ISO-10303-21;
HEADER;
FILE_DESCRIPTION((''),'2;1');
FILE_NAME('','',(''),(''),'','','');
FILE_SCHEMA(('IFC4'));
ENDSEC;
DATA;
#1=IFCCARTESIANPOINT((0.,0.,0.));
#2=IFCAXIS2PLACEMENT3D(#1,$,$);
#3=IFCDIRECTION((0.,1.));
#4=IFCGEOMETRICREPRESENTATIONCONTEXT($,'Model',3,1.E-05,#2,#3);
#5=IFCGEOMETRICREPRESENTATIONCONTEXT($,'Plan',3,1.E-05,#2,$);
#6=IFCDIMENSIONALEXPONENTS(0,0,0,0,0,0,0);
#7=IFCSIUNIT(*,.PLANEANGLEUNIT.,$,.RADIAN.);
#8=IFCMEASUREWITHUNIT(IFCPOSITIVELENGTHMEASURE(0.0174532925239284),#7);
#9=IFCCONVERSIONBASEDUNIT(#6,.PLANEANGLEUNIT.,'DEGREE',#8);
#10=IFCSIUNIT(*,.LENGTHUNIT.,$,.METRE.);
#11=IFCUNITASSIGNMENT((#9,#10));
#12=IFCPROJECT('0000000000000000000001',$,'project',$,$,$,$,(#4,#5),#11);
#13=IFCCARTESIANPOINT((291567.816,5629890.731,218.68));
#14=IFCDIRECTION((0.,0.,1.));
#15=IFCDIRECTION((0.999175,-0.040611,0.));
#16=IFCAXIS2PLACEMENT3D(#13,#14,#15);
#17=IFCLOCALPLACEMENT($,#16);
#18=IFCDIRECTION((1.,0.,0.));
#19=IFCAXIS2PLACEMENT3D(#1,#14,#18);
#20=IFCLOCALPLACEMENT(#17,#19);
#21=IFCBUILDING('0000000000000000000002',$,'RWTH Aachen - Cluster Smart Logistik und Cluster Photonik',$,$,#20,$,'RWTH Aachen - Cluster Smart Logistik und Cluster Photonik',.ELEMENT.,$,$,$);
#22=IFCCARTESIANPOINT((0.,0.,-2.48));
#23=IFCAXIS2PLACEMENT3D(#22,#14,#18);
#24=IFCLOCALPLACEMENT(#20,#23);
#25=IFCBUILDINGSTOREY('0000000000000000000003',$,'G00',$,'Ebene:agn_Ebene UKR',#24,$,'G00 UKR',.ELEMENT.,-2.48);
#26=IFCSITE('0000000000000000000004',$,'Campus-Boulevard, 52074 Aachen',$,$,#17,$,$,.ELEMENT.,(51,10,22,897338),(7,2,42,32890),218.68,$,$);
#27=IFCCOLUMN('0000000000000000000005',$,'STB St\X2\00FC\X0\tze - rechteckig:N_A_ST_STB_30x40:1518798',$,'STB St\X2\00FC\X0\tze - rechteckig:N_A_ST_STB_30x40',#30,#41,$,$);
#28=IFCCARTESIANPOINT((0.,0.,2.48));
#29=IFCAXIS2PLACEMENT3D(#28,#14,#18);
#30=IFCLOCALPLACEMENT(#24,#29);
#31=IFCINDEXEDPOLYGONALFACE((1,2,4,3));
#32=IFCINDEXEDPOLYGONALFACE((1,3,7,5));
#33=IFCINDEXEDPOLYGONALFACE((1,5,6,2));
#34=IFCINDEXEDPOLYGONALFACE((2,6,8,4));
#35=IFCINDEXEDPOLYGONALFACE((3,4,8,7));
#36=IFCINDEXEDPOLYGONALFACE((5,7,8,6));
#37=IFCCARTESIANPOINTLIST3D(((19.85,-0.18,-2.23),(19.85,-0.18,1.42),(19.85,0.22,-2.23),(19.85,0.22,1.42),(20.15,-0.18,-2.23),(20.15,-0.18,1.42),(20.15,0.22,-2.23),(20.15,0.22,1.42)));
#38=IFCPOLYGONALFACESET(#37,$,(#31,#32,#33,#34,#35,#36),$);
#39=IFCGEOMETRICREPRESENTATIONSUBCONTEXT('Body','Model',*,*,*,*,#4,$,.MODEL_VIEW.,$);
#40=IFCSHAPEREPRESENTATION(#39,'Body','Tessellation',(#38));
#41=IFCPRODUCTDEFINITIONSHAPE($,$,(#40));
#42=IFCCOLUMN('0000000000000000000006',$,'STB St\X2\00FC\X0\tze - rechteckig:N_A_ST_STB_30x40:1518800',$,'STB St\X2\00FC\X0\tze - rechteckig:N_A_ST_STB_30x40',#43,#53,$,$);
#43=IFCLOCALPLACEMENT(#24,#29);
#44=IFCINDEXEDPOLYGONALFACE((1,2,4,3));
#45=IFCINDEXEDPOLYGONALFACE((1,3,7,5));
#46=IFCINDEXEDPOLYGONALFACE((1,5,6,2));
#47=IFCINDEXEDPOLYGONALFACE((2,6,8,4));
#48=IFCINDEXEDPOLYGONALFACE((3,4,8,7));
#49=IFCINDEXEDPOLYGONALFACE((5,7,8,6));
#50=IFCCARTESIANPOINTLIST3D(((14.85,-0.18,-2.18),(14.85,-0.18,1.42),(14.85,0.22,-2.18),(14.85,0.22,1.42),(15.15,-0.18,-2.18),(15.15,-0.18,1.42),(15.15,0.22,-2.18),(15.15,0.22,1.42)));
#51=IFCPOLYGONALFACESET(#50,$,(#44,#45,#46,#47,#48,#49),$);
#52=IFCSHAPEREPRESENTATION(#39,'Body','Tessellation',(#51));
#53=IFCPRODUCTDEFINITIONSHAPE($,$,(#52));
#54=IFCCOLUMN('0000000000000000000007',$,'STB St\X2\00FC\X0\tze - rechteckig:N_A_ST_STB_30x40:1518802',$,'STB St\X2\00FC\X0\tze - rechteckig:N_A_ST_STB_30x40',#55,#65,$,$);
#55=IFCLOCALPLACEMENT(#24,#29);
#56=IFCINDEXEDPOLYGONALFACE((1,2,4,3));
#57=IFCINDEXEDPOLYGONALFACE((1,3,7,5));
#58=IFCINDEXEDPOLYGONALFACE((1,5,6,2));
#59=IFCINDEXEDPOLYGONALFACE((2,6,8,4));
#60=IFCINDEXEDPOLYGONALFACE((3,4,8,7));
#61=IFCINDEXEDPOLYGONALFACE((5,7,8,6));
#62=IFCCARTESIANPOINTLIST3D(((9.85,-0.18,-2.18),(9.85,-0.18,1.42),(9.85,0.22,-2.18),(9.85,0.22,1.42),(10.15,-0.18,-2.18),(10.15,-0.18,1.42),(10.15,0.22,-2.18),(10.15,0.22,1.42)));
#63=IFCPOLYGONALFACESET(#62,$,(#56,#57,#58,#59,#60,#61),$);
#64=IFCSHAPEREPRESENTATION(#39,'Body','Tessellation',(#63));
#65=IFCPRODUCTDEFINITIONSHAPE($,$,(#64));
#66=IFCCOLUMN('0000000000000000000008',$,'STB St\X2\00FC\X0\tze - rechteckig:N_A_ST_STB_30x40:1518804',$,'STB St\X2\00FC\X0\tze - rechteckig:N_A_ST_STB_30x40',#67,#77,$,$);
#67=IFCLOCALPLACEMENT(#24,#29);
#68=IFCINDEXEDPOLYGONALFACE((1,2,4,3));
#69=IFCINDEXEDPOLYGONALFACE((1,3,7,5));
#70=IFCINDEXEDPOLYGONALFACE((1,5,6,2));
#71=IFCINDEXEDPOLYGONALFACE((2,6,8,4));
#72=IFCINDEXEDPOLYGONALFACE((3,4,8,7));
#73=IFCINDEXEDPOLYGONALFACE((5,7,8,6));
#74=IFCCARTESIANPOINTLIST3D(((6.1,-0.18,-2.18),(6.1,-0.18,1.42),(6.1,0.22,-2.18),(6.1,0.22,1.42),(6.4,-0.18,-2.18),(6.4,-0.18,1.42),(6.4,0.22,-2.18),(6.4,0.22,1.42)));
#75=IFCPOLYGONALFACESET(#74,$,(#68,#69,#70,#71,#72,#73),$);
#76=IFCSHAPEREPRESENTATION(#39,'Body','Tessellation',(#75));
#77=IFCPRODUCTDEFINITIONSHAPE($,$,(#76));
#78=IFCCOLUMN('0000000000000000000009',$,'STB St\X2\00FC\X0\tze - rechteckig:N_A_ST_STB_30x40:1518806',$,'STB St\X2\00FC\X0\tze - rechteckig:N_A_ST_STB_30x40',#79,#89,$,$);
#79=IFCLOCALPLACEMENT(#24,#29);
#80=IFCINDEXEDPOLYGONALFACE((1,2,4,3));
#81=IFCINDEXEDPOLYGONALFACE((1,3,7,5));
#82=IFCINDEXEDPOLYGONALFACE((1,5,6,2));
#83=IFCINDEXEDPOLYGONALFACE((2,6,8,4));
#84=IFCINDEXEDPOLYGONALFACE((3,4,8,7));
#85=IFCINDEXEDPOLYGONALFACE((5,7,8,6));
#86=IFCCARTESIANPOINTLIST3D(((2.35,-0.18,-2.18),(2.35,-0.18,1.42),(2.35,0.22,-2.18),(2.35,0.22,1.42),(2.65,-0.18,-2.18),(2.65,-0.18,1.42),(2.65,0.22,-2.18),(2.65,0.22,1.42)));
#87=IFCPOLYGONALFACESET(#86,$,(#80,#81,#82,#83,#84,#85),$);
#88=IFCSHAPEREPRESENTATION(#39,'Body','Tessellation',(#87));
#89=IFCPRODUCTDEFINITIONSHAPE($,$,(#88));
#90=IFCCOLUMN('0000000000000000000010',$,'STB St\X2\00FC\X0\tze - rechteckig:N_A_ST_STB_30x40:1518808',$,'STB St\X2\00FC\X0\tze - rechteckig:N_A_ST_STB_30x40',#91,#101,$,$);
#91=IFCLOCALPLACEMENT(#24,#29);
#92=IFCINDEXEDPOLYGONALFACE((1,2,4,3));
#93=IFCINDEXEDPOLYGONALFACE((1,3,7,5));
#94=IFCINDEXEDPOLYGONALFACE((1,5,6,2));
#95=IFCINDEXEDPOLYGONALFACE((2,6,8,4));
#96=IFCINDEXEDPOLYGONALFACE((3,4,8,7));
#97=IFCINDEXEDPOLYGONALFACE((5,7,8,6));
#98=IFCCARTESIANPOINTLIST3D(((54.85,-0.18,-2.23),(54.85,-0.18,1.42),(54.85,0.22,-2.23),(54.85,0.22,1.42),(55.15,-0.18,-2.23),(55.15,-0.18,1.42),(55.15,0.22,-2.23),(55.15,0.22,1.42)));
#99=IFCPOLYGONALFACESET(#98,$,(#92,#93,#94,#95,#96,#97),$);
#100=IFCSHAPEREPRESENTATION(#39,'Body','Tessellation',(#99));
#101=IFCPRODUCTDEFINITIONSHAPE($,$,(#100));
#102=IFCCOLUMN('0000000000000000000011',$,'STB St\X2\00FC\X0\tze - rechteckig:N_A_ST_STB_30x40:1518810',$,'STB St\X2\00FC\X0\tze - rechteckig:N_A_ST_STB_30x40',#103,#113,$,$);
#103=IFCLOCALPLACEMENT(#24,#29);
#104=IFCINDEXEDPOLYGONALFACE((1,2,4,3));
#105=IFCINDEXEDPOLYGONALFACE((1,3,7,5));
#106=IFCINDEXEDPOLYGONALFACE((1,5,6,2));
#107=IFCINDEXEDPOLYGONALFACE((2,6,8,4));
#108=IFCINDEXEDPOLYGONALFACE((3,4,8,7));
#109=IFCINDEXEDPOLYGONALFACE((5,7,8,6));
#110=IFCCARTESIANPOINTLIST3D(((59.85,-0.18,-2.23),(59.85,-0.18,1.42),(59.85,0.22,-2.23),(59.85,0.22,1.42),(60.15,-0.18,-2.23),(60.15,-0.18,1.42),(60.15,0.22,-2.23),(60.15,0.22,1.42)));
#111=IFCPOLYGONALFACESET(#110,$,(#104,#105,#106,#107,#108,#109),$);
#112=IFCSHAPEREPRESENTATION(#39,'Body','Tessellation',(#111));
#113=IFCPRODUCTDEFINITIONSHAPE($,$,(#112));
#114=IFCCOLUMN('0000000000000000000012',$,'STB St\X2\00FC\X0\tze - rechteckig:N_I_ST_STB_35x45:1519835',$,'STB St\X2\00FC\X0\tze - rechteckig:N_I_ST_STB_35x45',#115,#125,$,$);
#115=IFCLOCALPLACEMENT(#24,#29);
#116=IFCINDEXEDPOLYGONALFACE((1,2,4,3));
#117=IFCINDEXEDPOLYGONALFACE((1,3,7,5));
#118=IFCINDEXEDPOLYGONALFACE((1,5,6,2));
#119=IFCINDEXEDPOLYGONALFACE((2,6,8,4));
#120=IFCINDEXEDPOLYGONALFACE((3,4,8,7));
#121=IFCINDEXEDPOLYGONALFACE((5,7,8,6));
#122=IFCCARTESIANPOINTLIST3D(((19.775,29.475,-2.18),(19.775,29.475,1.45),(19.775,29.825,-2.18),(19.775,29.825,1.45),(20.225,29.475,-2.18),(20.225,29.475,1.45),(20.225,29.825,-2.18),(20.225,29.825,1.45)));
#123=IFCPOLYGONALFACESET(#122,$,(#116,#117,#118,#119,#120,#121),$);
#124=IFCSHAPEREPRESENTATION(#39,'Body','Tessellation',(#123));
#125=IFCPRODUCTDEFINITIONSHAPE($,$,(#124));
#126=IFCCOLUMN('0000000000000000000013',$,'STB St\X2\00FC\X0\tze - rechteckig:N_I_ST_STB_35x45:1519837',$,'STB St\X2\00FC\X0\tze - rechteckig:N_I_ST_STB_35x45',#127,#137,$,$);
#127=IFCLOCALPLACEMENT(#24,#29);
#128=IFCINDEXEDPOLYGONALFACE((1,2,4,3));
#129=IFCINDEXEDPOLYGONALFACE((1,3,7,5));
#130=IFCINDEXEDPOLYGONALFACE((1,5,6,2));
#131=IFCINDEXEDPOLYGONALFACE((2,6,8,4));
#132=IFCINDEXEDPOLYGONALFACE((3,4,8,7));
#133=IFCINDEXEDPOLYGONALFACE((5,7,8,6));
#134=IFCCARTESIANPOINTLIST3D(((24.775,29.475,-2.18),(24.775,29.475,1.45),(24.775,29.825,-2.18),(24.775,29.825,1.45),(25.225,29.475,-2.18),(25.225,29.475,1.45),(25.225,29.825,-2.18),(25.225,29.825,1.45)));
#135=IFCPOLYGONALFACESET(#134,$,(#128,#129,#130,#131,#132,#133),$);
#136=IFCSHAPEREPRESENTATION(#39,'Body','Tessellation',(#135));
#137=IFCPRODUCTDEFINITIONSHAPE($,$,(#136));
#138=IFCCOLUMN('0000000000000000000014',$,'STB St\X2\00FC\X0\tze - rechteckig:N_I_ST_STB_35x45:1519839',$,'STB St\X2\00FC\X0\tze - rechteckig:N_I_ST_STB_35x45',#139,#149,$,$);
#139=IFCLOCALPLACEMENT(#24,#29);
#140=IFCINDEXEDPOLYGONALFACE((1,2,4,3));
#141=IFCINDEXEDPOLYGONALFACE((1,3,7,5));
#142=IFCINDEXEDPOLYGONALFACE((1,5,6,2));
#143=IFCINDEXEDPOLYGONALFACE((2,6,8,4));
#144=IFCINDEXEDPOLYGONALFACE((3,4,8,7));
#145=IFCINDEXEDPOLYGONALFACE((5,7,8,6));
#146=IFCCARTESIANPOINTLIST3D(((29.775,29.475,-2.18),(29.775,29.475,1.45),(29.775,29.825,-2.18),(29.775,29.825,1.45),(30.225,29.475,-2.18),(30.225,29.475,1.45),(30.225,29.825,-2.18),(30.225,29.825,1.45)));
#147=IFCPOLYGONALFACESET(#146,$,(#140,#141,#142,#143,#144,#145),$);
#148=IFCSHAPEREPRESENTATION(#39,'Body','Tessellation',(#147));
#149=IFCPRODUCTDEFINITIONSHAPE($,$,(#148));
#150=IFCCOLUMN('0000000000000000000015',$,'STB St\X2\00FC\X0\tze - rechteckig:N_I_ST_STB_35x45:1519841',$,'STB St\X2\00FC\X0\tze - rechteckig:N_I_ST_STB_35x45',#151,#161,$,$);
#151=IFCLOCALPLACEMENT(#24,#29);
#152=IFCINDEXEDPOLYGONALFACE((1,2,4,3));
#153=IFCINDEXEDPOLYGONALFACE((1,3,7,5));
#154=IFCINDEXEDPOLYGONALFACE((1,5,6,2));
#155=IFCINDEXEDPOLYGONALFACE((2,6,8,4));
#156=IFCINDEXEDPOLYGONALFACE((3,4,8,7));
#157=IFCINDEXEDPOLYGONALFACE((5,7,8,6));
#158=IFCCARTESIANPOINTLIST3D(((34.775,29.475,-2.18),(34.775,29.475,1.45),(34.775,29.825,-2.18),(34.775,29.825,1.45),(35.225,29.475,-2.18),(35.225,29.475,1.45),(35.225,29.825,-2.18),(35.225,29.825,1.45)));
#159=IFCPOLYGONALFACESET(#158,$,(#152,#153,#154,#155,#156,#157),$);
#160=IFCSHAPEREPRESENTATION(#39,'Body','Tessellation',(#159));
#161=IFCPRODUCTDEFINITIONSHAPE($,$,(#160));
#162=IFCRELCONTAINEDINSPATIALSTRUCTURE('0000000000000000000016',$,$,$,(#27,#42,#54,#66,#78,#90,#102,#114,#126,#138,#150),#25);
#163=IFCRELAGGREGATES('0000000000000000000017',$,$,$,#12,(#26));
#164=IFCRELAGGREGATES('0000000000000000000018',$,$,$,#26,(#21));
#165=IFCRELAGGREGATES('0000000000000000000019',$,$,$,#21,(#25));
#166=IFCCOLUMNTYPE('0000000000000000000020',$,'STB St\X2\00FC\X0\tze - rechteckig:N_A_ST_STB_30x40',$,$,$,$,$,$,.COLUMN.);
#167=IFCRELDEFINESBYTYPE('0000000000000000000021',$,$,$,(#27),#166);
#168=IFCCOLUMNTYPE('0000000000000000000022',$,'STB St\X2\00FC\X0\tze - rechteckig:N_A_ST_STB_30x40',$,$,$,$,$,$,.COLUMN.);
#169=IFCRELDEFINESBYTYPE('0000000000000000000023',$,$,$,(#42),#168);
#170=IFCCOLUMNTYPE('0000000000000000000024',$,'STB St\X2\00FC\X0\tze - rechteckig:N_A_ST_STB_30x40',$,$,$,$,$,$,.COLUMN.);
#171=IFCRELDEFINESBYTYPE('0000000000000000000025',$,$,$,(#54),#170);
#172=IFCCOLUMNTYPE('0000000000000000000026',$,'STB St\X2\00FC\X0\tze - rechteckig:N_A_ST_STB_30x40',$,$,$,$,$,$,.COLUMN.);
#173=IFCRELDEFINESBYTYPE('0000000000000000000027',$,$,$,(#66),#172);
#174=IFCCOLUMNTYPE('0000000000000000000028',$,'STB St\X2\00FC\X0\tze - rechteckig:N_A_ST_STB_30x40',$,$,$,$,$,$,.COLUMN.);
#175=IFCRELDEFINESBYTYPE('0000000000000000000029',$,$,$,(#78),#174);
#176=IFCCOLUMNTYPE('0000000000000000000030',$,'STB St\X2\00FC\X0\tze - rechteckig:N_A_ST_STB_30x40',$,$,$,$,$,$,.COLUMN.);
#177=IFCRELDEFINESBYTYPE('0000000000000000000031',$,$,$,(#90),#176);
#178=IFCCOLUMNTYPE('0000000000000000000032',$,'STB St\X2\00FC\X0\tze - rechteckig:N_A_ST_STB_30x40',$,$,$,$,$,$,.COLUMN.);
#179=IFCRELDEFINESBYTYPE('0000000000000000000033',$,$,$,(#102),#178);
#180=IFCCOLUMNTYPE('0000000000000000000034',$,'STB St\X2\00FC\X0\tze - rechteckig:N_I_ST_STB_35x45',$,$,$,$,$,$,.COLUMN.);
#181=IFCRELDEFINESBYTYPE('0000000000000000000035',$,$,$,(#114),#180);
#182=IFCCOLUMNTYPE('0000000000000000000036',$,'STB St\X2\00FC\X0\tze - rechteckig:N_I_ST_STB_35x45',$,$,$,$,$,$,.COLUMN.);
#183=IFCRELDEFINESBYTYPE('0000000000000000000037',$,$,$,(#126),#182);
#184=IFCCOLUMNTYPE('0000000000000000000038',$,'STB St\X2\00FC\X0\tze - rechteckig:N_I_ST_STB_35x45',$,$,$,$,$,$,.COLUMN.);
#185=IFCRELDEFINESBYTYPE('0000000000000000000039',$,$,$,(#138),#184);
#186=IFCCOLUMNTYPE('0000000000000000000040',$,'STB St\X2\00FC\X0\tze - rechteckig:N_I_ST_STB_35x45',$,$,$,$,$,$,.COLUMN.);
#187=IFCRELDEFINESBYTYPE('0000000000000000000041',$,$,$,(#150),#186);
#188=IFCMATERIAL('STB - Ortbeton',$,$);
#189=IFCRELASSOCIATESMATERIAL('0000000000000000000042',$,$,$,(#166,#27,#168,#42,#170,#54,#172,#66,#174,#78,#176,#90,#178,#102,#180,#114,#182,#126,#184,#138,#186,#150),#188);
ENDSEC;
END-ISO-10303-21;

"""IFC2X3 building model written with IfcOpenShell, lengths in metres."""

from ifc_helpers import new_model, entity, si_unit, converted_unit, direction, frame, frame_2d, origin, origin_with_axes, origin_2d_with_axis, place, context, subcontext, project, spatial, rectangle, extrude, source, transform, mapped, material, type_object, element, save


model = new_model("IFC2X3")

# Units and contexts
model_context = context("Model", 3, precision=1e-05, world=origin(), true_north=direction((0.0, 1.0)))
plan_context = context("Plan", 3, precision=1e-05, world=origin())
body_context = subcontext(model_context, "Body", "Model", "MODEL_VIEW")
ifc_project = project(units=[converted_unit("PLANEANGLEUNIT", "DEGREE", entity("IfcPositiveLengthMeasure", 0.0174532925239284), si_unit("PLANEANGLEUNIT", "RADIAN"), dimensions=[0, 0, 0, 0, 0, 0, 0]), si_unit("LENGTHUNIT", "METRE")], contexts=[model_context, plan_context])

# Site, building, storey
site_placement = place(None, frame((291567.816, 5629890.731, 218.68), z_axis=(0.0, 0.0, 1.0), x_axis=(0.999175, -0.040611, 0.0)))
site = spatial("IfcSite", under=ifc_project, at=site_placement, Name="Campus-Boulevard, 52074 Aachen", CompositionType="ELEMENT", RefLatitude=(51, 10, 22, 897338), RefLongitude=(7, 2, 42, 32890), RefElevation=218.68)
building_placement = place(site_placement, origin_with_axes())
building = spatial("IfcBuilding", under=site, at=building_placement, Name="RWTH Aachen - Cluster Smart Logistik und Cluster Photonik", LongName="RWTH Aachen - Cluster Smart Logistik und Cluster Photonik", CompositionType="ELEMENT")
storey_placement = place(building_placement, frame((0.0, 0.0, -2.48), z_axis=(0.0, 0.0, 1.0), x_axis=(1.0, 0.0, 0.0)))
storey = spatial("IfcBuildingStorey", under=building, at=storey_placement, Name="G00", ObjectType="Ebene:agn_Ebene UKR", LongName="G00 UKR", CompositionType="ELEMENT", Elevation=-2.48)

# Shared definitions
ifc_material = material(Name="STB - Ortbeton")

# Columns
column_type_1 = type_object("IfcColumnType", Name="STB Stütze - rechteckig:N_A_ST_STB_30x40", PredefinedType="COLUMN", material=ifc_material)
shared_shape_1 = source(origin(), body_context, "Body", "SweptSolid", [
    extrude(rectangle(XDim=0.4, YDim=0.3, at=origin_2d_with_axis()), frame((20.0, 0.02, -2.23), z_axis=(0.0, 0.0, 1.0), x_axis=(0.0, -1.0, 0.0)), (0.0, 0.0, 1.0), 3.65),
])
column_1_placement = place(storey_placement, frame((0.0, 0.0, 2.48), z_axis=(0.0, 0.0, 1.0), x_axis=(1.0, 0.0, 0.0)))
element("IfcColumn", 1, at=column_1_placement, inside=storey, type_object=column_type_1, material=ifc_material, Name="STB Stütze - rechteckig:N_A_ST_STB_30x40:1518798", ObjectType="STB Stütze - rechteckig:N_A_ST_STB_30x40", context=body_context, shape_type="MappedRepresentation", body=[
    mapped(shared_shape_1, transform((0.0, 0.0, 0.0), scale=1.0)),
])
column_type_2 = type_object("IfcColumnType", Name="STB Stütze - rechteckig:N_A_ST_STB_30x40", PredefinedType="COLUMN", material=ifc_material)
shared_shape_2 = source(origin(), body_context, "Body", "SweptSolid", [
    extrude(rectangle(XDim=0.4, YDim=0.3, at=origin_2d_with_axis()), frame((15.0, 0.02, -2.18), z_axis=(0.0, 0.0, 1.0), x_axis=(0.0, -1.0, 0.0)), (0.0, 0.0, 1.0), 3.6),
])
column_2_placement = place(storey_placement, frame((0.0, 0.0, 2.48), z_axis=(0.0, 0.0, 1.0), x_axis=(1.0, 0.0, 0.0)))
element("IfcColumn", 2, at=column_2_placement, inside=storey, type_object=column_type_2, material=ifc_material, Name="STB Stütze - rechteckig:N_A_ST_STB_30x40:1518800", ObjectType="STB Stütze - rechteckig:N_A_ST_STB_30x40", context=body_context, shape_type="MappedRepresentation", body=[
    mapped(shared_shape_2, transform((0.0, 0.0, 0.0), scale=1.0)),
])
column_type_3 = type_object("IfcColumnType", Name="STB Stütze - rechteckig:N_A_ST_STB_30x40", PredefinedType="COLUMN", material=ifc_material)
shared_shape_3 = source(origin(), body_context, "Body", "SweptSolid", [
    extrude(rectangle(XDim=0.4, YDim=0.3, at=origin_2d_with_axis()), frame((10.0, 0.02, -2.18), z_axis=(0.0, 0.0, 1.0), x_axis=(0.0, -1.0, 0.0)), (0.0, 0.0, 1.0), 3.6),
])
column_3_placement = place(storey_placement, frame((0.0, 0.0, 2.48), z_axis=(0.0, 0.0, 1.0), x_axis=(1.0, 0.0, 0.0)))
element("IfcColumn", 3, at=column_3_placement, inside=storey, type_object=column_type_3, material=ifc_material, Name="STB Stütze - rechteckig:N_A_ST_STB_30x40:1518802", ObjectType="STB Stütze - rechteckig:N_A_ST_STB_30x40", context=body_context, shape_type="MappedRepresentation", body=[
    mapped(shared_shape_3, transform((0.0, 0.0, 0.0), scale=1.0)),
])
column_type_4 = type_object("IfcColumnType", Name="STB Stütze - rechteckig:N_A_ST_STB_30x40", PredefinedType="COLUMN", material=ifc_material)
shared_shape_4 = source(origin(), body_context, "Body", "SweptSolid", [
    extrude(rectangle(XDim=0.4, YDim=0.3, at=frame_2d((0.0, 0.0), x_axis=(1.0, 0.0))), frame((6.25, 0.02, -2.18), z_axis=(0.0, 0.0, 1.0), x_axis=(0.0, -1.0, 0.0)), (0.0, 0.0, 1.0), 3.6),
])
column_4_placement = place(storey_placement, frame((0.0, 0.0, 2.48), z_axis=(0.0, 0.0, 1.0), x_axis=(1.0, 0.0, 0.0)))
element("IfcColumn", 4, at=column_4_placement, inside=storey, type_object=column_type_4, material=ifc_material, Name="STB Stütze - rechteckig:N_A_ST_STB_30x40:1518804", ObjectType="STB Stütze - rechteckig:N_A_ST_STB_30x40", context=body_context, shape_type="MappedRepresentation", body=[
    mapped(shared_shape_4, transform((0.0, 0.0, 0.0), scale=1.0)),
])
column_type_5 = type_object("IfcColumnType", Name="STB Stütze - rechteckig:N_A_ST_STB_30x40", PredefinedType="COLUMN", material=ifc_material)
shared_shape_5 = source(origin(), body_context, "Body", "SweptSolid", [
    extrude(rectangle(XDim=0.4, YDim=0.3, at=origin_2d_with_axis()), frame((2.5, 0.02, -2.18), z_axis=(0.0, 0.0, 1.0), x_axis=(0.0, -1.0, 0.0)), (0.0, 0.0, 1.0), 3.6),
])
column_5_placement = place(storey_placement, frame((0.0, 0.0, 2.48), z_axis=(0.0, 0.0, 1.0), x_axis=(1.0, 0.0, 0.0)))
element("IfcColumn", 5, at=column_5_placement, inside=storey, type_object=column_type_5, material=ifc_material, Name="STB Stütze - rechteckig:N_A_ST_STB_30x40:1518806", ObjectType="STB Stütze - rechteckig:N_A_ST_STB_30x40", context=body_context, shape_type="MappedRepresentation", body=[
    mapped(shared_shape_5, transform((0.0, 0.0, 0.0), scale=1.0)),
])
column_type_6 = type_object("IfcColumnType", Name="STB Stütze - rechteckig:N_A_ST_STB_30x40", PredefinedType="COLUMN", material=ifc_material)
shared_shape_6 = source(origin(), body_context, "Body", "SweptSolid", [
    extrude(rectangle(XDim=0.4, YDim=0.3, at=origin_2d_with_axis()), frame((55.0, 0.02, -2.23), z_axis=(0.0, 0.0, 1.0), x_axis=(0.0, -1.0, 0.0)), (0.0, 0.0, 1.0), 3.65),
])
column_6_placement = place(storey_placement, frame((0.0, 0.0, 2.48), z_axis=(0.0, 0.0, 1.0), x_axis=(1.0, 0.0, 0.0)))
element("IfcColumn", 6, at=column_6_placement, inside=storey, type_object=column_type_6, material=ifc_material, Name="STB Stütze - rechteckig:N_A_ST_STB_30x40:1518808", ObjectType="STB Stütze - rechteckig:N_A_ST_STB_30x40", context=body_context, shape_type="MappedRepresentation", body=[
    mapped(shared_shape_6, transform((0.0, 0.0, 0.0), scale=1.0)),
])
column_type_7 = type_object("IfcColumnType", Name="STB Stütze - rechteckig:N_A_ST_STB_30x40", PredefinedType="COLUMN", material=ifc_material)
shared_shape_7 = source(origin(), body_context, "Body", "SweptSolid", [
    extrude(rectangle(XDim=0.4, YDim=0.3, at=origin_2d_with_axis()), frame((60.0, 0.02, -2.23), z_axis=(0.0, 0.0, 1.0), x_axis=(0.0, -1.0, 0.0)), (0.0, 0.0, 1.0), 3.65),
])
column_7_placement = place(storey_placement, frame((0.0, 0.0, 2.48), z_axis=(0.0, 0.0, 1.0), x_axis=(1.0, 0.0, 0.0)))
element("IfcColumn", 7, at=column_7_placement, inside=storey, type_object=column_type_7, material=ifc_material, Name="STB Stütze - rechteckig:N_A_ST_STB_30x40:1518810", ObjectType="STB Stütze - rechteckig:N_A_ST_STB_30x40", context=body_context, shape_type="MappedRepresentation", body=[
    mapped(shared_shape_7, transform((0.0, 0.0, 0.0), scale=1.0)),
])
column_type_8 = type_object("IfcColumnType", Name="STB Stütze - rechteckig:N_I_ST_STB_35x45", PredefinedType="COLUMN", material=ifc_material)
shared_shape_8 = source(origin(), body_context, "Body", "SweptSolid", [
    extrude(rectangle(XDim=0.35, YDim=0.45, at=origin_2d_with_axis()), frame((20.0, 29.65, -2.18), z_axis=(0.0, 0.0, 1.0), x_axis=(0.0, -1.0, 0.0)), (0.0, 0.0, 1.0), 3.63),
])
column_8_placement = place(storey_placement, frame((0.0, 0.0, 2.48), z_axis=(0.0, 0.0, 1.0), x_axis=(1.0, 0.0, 0.0)))
element("IfcColumn", 8, at=column_8_placement, inside=storey, type_object=column_type_8, material=ifc_material, Name="STB Stütze - rechteckig:N_I_ST_STB_35x45:1519835", ObjectType="STB Stütze - rechteckig:N_I_ST_STB_35x45", context=body_context, shape_type="MappedRepresentation", body=[
    mapped(shared_shape_8, transform((0.0, 0.0, 0.0), scale=1.0)),
])
column_type_9 = type_object("IfcColumnType", Name="STB Stütze - rechteckig:N_I_ST_STB_35x45", PredefinedType="COLUMN", material=ifc_material)
shared_shape_9 = source(origin(), body_context, "Body", "SweptSolid", [
    extrude(rectangle(XDim=0.35, YDim=0.45, at=origin_2d_with_axis()), frame((25.0, 29.65, -2.18), z_axis=(0.0, 0.0, 1.0), x_axis=(0.0, -1.0, 0.0)), (0.0, 0.0, 1.0), 3.63),
])
column_9_placement = place(storey_placement, frame((0.0, 0.0, 2.48), z_axis=(0.0, 0.0, 1.0), x_axis=(1.0, 0.0, 0.0)))
element("IfcColumn", 9, at=column_9_placement, inside=storey, type_object=column_type_9, material=ifc_material, Name="STB Stütze - rechteckig:N_I_ST_STB_35x45:1519837", ObjectType="STB Stütze - rechteckig:N_I_ST_STB_35x45", context=body_context, shape_type="MappedRepresentation", body=[
    mapped(shared_shape_9, transform((0.0, 0.0, 0.0), scale=1.0)),
])
column_type_10 = type_object("IfcColumnType", Name="STB Stütze - rechteckig:N_I_ST_STB_35x45", PredefinedType="COLUMN", material=ifc_material)
shared_shape_10 = source(origin(), body_context, "Body", "SweptSolid", [
    extrude(rectangle(XDim=0.35, YDim=0.45, at=origin_2d_with_axis()), frame((30.0, 29.65, -2.18), z_axis=(0.0, 0.0, 1.0), x_axis=(0.0, -1.0, 0.0)), (0.0, 0.0, 1.0), 3.63),
])
column_10_placement = place(storey_placement, frame((0.0, 0.0, 2.48), z_axis=(0.0, 0.0, 1.0), x_axis=(1.0, 0.0, 0.0)))
element("IfcColumn", 10, at=column_10_placement, inside=storey, type_object=column_type_10, material=ifc_material, Name="STB Stütze - rechteckig:N_I_ST_STB_35x45:1519839", ObjectType="STB Stütze - rechteckig:N_I_ST_STB_35x45", context=body_context, shape_type="MappedRepresentation", body=[
    mapped(shared_shape_10, transform((0.0, 0.0, 0.0), scale=1.0)),
])
column_type_11 = type_object("IfcColumnType", Name="STB Stütze - rechteckig:N_I_ST_STB_35x45", PredefinedType="COLUMN", material=ifc_material)
shared_shape_11 = source(origin(), body_context, "Body", "SweptSolid", [
    extrude(rectangle(XDim=0.35, YDim=0.45, at=origin_2d_with_axis()), frame((35.0, 29.65, -2.18), z_axis=(0.0, 0.0, 1.0), x_axis=(0.0, -1.0, 0.0)), (0.0, 0.0, 1.0), 3.63),
])
column_11_placement = place(storey_placement, frame((0.0, 0.0, 2.48), z_axis=(0.0, 0.0, 1.0), x_axis=(1.0, 0.0, 0.0)))
element("IfcColumn", 11, at=column_11_placement, inside=storey, type_object=column_type_11, material=ifc_material, Name="STB Stütze - rechteckig:N_I_ST_STB_35x45:1519841", ObjectType="STB Stütze - rechteckig:N_I_ST_STB_35x45", context=body_context, shape_type="MappedRepresentation", body=[
    mapped(shared_shape_11, transform((0.0, 0.0, 0.0), scale=1.0)),
])

save(model, "model.ifc")
